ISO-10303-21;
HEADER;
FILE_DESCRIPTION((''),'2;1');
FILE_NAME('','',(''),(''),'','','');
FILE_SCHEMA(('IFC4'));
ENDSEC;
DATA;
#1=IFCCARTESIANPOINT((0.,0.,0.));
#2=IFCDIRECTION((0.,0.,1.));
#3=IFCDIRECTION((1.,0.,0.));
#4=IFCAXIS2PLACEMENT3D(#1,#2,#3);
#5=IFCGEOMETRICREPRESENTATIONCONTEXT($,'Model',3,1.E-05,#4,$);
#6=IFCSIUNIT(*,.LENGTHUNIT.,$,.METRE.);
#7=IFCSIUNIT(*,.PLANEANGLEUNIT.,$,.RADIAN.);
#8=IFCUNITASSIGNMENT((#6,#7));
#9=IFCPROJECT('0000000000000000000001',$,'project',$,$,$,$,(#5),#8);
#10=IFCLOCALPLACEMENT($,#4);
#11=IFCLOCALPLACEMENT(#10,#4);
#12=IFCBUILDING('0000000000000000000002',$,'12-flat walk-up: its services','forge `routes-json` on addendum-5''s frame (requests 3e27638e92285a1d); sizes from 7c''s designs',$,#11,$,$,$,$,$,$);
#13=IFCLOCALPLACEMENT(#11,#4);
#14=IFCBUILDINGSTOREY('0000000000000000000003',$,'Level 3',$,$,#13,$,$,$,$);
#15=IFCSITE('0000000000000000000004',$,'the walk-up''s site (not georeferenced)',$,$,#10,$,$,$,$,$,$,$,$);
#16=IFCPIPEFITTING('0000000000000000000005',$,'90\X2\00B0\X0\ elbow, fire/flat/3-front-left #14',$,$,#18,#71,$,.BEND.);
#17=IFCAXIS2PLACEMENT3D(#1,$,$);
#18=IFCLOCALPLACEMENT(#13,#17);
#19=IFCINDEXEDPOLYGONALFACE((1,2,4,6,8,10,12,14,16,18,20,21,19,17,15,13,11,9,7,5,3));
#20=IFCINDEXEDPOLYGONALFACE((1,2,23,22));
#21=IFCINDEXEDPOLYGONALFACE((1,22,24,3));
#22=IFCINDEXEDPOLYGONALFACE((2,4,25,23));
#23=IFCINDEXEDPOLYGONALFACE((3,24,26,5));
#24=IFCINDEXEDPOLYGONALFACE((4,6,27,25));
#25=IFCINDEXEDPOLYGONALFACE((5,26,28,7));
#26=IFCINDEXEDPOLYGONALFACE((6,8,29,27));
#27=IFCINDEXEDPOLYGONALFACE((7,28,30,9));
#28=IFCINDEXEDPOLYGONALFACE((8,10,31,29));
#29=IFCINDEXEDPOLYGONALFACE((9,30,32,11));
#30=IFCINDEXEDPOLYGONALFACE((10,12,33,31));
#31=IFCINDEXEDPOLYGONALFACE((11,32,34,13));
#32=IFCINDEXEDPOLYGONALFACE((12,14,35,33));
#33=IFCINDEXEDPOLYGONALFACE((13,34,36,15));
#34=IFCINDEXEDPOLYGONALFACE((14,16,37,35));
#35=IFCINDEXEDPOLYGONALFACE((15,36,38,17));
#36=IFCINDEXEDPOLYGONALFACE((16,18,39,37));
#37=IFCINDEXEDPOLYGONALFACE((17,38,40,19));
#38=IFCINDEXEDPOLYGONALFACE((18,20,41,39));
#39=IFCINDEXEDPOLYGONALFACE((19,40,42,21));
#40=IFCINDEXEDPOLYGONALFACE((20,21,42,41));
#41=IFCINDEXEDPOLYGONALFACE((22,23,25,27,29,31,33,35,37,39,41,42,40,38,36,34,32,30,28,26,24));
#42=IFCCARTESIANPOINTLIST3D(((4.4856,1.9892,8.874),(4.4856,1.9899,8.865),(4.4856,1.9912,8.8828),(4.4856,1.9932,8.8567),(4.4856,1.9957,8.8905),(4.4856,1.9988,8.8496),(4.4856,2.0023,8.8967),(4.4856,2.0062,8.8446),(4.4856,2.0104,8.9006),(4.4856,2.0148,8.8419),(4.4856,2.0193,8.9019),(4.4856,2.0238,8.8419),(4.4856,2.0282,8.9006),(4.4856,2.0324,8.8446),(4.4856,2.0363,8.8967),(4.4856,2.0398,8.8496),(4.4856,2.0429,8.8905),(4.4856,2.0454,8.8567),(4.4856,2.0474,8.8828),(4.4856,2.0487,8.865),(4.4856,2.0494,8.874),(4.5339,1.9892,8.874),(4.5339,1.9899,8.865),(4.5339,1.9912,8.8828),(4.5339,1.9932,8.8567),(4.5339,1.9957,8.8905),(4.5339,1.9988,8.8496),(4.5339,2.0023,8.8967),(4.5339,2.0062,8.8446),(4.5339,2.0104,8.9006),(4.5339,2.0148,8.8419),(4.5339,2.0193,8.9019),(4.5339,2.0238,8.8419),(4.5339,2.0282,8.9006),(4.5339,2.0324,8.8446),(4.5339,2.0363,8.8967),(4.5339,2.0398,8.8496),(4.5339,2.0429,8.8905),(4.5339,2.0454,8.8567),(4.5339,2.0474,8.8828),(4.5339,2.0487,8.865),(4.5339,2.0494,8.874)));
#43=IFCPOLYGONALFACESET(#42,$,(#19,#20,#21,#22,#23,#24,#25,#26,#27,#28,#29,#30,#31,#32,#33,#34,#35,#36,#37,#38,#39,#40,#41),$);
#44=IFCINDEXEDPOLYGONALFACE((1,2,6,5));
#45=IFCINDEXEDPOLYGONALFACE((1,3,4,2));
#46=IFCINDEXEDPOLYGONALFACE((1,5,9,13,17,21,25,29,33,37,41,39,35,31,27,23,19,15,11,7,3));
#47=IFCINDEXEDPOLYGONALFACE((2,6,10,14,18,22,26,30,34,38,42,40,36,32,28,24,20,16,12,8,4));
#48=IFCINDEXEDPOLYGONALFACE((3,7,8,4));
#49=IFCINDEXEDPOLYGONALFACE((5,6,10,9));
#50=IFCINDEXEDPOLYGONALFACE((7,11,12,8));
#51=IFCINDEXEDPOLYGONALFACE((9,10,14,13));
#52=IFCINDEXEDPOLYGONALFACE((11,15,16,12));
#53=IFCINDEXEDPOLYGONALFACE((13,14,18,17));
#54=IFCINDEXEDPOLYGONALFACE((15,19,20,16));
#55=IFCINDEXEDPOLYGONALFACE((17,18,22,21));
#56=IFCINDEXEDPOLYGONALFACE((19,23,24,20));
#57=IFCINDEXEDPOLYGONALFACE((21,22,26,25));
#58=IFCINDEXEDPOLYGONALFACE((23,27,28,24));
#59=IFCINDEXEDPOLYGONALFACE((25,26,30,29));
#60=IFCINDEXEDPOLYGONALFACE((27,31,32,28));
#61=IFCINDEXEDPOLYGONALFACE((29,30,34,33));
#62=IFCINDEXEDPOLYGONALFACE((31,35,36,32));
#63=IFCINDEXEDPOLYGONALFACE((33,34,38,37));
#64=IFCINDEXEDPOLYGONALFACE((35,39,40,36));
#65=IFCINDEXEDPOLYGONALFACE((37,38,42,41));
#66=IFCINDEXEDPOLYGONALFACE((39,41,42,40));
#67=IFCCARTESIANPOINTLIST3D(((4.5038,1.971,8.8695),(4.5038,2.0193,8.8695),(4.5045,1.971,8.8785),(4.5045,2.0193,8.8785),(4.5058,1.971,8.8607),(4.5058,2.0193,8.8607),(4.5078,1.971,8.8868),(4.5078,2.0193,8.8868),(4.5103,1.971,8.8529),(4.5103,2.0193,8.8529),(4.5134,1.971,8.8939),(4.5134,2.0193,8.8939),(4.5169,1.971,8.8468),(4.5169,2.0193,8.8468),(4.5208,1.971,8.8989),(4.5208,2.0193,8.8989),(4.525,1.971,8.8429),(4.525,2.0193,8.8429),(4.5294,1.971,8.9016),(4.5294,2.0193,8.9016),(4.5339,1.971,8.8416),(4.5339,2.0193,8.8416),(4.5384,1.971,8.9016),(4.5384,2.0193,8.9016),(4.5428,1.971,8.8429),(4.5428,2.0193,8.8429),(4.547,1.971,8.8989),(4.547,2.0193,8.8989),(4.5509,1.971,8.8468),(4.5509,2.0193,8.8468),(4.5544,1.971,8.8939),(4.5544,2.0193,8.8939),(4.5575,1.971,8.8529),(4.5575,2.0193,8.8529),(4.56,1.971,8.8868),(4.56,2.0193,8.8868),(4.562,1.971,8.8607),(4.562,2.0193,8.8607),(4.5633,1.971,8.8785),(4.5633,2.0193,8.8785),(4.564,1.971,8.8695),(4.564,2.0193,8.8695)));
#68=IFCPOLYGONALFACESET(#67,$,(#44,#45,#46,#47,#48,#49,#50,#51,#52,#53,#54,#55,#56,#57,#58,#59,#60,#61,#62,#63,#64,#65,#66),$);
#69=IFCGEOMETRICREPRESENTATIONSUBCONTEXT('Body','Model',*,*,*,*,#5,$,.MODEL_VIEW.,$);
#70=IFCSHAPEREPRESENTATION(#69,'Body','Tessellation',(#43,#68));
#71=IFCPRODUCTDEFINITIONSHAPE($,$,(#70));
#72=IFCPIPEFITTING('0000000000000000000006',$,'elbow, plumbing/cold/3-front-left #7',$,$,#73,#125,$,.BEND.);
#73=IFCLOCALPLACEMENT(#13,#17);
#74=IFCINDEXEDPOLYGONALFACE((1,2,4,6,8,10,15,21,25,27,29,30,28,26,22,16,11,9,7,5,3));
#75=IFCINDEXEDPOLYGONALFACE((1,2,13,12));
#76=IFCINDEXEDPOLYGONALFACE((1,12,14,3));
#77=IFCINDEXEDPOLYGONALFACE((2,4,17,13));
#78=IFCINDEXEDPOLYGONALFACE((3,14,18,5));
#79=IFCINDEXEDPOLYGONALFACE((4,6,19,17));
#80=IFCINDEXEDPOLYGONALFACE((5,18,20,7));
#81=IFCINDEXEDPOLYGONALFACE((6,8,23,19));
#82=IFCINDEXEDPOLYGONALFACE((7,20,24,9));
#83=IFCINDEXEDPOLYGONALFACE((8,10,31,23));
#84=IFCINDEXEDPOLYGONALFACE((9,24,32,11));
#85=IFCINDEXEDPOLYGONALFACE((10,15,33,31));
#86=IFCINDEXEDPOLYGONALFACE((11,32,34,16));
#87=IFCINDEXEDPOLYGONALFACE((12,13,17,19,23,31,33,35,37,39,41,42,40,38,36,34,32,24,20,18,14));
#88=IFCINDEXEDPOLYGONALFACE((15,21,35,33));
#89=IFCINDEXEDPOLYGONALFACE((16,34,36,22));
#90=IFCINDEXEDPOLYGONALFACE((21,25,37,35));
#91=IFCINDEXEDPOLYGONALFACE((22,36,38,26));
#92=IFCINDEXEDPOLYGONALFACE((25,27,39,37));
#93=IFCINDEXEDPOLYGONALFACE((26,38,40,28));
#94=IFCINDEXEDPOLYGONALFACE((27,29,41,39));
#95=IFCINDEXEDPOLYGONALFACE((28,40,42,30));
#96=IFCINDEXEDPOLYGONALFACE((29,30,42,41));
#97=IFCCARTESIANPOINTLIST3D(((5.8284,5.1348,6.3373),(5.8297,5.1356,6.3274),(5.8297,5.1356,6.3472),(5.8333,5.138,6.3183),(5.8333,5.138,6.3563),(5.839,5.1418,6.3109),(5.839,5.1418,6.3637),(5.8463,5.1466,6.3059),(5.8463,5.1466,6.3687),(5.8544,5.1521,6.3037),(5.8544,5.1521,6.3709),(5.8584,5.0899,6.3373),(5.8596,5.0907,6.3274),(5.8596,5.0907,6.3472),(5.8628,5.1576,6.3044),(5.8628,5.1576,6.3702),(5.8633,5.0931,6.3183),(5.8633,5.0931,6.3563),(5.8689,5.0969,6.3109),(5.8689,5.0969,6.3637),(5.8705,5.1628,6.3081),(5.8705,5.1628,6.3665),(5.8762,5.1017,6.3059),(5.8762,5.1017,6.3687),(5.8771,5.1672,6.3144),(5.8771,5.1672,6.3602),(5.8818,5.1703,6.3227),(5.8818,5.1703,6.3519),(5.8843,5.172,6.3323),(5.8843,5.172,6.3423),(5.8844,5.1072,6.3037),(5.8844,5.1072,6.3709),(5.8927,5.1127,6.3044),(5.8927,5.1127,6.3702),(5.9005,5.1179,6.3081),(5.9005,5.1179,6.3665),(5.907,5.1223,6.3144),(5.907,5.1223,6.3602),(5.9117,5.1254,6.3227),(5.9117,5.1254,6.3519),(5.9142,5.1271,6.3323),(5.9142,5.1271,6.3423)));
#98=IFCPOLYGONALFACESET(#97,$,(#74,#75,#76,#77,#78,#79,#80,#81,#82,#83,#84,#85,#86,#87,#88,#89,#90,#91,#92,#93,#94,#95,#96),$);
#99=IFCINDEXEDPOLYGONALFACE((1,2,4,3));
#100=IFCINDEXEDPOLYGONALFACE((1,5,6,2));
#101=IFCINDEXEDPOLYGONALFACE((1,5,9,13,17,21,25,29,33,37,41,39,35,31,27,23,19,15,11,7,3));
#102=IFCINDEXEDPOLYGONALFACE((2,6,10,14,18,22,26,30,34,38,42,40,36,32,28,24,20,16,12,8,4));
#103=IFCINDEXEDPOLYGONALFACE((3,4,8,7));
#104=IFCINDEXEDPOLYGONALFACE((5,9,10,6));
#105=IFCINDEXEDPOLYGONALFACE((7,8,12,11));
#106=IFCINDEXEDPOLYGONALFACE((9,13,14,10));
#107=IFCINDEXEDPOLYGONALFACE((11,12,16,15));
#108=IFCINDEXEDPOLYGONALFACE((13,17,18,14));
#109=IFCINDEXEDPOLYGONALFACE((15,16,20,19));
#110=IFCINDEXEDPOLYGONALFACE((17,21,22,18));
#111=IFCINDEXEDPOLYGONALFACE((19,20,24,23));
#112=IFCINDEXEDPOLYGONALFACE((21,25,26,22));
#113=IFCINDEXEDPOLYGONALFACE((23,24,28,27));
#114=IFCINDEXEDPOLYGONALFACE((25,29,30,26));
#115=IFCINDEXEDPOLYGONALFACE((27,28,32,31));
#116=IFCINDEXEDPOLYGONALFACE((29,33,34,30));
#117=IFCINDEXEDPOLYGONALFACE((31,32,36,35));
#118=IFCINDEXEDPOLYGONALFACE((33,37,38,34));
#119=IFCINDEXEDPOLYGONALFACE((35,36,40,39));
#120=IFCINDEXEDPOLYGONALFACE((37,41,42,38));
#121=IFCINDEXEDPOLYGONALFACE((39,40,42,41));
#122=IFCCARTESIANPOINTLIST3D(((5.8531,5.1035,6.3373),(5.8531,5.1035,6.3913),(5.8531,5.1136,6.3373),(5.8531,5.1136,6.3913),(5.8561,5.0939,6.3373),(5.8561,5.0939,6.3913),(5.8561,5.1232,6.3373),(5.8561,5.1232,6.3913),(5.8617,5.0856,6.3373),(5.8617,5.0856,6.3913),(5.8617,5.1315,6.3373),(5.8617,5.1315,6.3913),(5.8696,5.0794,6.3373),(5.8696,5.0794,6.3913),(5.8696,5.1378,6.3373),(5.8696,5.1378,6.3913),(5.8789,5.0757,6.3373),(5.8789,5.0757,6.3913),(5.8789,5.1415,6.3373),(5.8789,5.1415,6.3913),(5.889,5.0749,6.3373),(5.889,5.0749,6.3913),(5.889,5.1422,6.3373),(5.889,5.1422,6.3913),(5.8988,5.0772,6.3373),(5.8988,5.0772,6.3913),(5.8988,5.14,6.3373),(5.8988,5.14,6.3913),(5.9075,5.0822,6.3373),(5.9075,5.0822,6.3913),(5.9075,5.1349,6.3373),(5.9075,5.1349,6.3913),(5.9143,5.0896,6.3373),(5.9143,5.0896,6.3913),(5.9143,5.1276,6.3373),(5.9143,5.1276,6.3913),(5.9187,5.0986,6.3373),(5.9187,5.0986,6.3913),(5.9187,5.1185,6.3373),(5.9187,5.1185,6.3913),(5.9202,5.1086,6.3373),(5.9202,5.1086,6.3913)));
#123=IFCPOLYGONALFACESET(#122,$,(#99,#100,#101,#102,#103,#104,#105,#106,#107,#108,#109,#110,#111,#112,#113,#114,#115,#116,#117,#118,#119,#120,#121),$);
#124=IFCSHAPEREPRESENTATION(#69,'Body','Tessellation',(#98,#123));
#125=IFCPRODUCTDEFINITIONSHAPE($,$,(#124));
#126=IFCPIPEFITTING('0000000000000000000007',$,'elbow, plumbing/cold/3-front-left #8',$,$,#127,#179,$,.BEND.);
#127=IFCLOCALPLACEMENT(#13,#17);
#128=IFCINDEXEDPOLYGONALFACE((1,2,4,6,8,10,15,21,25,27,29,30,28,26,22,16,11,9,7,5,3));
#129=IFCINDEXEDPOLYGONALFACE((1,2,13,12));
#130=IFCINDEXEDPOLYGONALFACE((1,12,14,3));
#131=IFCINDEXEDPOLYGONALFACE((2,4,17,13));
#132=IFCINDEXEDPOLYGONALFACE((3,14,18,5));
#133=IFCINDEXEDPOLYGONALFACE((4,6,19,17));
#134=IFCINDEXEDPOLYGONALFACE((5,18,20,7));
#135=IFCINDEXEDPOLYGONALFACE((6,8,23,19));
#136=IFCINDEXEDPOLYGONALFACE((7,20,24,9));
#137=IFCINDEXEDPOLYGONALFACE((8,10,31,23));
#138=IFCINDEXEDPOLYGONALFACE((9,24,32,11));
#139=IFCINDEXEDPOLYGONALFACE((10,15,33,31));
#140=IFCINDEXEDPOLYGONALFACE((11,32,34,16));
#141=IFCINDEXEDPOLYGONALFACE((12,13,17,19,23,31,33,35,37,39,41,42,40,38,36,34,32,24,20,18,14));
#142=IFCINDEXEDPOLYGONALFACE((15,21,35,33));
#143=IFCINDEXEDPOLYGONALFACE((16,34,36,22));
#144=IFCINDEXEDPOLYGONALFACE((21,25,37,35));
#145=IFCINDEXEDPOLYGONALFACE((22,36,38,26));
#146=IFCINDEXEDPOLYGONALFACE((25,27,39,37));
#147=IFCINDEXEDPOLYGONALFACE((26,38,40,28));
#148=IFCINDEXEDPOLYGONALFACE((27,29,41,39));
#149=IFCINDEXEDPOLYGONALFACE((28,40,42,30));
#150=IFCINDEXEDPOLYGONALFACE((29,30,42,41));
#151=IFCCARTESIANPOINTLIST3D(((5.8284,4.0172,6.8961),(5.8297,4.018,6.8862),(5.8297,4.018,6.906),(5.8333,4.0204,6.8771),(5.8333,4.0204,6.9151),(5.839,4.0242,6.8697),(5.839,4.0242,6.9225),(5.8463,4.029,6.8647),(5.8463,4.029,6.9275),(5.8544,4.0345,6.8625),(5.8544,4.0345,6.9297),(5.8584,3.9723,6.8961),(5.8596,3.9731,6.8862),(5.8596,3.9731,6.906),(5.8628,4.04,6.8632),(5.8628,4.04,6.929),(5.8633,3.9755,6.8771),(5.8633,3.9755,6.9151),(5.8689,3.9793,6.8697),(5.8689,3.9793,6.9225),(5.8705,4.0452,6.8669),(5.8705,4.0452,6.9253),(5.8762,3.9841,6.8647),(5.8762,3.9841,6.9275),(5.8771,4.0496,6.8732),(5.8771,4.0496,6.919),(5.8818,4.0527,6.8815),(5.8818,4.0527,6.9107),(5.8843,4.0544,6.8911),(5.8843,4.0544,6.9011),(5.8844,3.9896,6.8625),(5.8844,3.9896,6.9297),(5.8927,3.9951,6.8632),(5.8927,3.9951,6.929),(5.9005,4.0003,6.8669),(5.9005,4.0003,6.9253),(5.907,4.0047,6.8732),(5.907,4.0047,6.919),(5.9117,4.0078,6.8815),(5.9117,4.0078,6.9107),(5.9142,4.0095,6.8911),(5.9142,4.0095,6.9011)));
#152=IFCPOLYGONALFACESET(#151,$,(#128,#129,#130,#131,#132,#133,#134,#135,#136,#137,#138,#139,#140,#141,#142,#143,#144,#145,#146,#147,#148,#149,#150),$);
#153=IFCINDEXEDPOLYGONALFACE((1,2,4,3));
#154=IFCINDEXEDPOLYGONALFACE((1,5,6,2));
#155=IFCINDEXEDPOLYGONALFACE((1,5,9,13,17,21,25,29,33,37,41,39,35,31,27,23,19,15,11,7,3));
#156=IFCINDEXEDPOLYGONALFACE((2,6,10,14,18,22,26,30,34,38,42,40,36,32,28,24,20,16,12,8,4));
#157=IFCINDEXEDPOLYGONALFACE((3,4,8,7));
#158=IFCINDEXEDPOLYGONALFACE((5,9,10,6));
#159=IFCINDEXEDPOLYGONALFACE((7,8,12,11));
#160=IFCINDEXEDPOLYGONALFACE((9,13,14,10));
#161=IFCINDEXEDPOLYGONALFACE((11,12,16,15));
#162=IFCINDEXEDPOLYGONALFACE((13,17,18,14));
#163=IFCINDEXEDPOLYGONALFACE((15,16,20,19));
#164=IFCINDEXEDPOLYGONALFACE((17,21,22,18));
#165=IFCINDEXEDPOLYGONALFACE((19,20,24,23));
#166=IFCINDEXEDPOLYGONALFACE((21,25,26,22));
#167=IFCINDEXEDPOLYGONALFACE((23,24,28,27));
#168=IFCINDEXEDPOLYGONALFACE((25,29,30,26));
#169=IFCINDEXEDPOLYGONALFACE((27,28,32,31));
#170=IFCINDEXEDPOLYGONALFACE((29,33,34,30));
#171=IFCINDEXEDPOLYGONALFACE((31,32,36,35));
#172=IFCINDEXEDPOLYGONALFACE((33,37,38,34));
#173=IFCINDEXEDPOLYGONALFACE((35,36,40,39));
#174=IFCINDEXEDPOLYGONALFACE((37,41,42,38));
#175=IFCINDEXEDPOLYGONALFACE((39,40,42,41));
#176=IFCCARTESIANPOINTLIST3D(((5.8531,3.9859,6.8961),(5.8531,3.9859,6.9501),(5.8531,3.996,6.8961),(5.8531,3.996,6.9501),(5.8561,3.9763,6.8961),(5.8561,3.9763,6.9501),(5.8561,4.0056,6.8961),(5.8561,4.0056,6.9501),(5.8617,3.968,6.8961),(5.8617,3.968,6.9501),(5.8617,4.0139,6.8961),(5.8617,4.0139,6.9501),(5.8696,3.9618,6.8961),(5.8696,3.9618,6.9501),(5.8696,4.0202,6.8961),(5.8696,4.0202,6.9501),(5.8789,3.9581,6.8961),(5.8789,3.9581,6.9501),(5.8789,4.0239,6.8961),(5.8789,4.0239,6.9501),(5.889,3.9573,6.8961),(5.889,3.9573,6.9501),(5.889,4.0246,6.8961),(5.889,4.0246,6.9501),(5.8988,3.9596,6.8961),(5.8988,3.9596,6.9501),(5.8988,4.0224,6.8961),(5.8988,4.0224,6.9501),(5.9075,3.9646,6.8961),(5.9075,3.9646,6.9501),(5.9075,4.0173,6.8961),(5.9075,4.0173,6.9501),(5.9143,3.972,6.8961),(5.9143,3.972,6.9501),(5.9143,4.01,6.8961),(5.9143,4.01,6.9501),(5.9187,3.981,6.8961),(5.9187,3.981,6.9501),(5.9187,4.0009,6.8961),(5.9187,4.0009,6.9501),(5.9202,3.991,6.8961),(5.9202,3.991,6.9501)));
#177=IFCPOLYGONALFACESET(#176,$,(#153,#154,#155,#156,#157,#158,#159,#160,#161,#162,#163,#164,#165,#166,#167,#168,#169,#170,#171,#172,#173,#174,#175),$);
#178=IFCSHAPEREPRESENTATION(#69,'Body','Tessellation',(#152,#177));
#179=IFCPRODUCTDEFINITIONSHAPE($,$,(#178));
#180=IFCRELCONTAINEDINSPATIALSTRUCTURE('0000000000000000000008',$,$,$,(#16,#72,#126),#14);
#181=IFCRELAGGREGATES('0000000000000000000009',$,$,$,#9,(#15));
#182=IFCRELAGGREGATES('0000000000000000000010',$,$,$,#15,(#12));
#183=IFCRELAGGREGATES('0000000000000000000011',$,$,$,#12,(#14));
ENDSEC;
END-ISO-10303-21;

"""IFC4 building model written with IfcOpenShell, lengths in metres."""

from ifc_helpers import new_model, entity, si_unit, frame, origin_with_axes, place, context, subcontext, project, spatial, element, save


model = new_model("IFC4")

# Units and contexts
model_context = context("Model", 3, precision=1e-05, world=origin_with_axes())
body_context = subcontext(model_context, "Body", "Model", "MODEL_VIEW")
ifc_project = project(units=[si_unit("LENGTHUNIT", "METRE"), si_unit("PLANEANGLEUNIT", "RADIAN")], contexts=[model_context])

# Site, building, storey
site_placement = place(None, origin_with_axes())
site = spatial("IfcSite", under=ifc_project, at=site_placement, Name="the walk-up's site (not georeferenced)")
building_placement = place(site_placement, origin_with_axes())
building = spatial("IfcBuilding", under=site, at=building_placement, Name="12-flat walk-up: its services", Description="forge `routes-json` on addendum-5's frame (requests 3e27638e92285a1d); sizes from 7c's designs")
storey_placement = place(building_placement, origin_with_axes())
storey = spatial("IfcBuildingStorey", under=building, at=storey_placement, Name="Level 3")

# Pipe fittings
pipe_fitting_1_placement = place(storey_placement, frame((4.4856, 2.0193, 8.8717), z_axis=(0.0, 0.0, 1.0), x_axis=(1.0, 0.0, 0.0)))
element("IfcPipeFitting", 1, at=pipe_fitting_1_placement, inside=storey, Name="90° elbow, fire/flat/3-front-left #14", PredefinedType="BEND", context=body_context, shape_type="AdvancedSweptSolid", body=[
    entity("IfcSweptDiskSolid", entity("IfcPolyline", [entity("IfcCartesianPoint", [0.0, 0.0, 0.0]), entity("IfcCartesianPoint", [0.0483, 0.0, 0.0])]), 0.0302),
    entity("IfcSweptDiskSolid", entity("IfcPolyline", [entity("IfcCartesianPoint", [0.0483, 0.0, 0.0]), entity("IfcCartesianPoint", [0.0483, -0.0483, 0.0])]), 0.0302),
])
pipe_fitting_2_placement = place(storey_placement, frame((5.8565, 5.1535, 6.3373), z_axis=(0.0, 0.0, 1.0), x_axis=(1.0, 0.0, 0.0)))
element("IfcPipeFitting", 2, at=pipe_fitting_2_placement, inside=storey, Name="elbow, plumbing/cold/3-front-left #7", PredefinedType="BEND", context=body_context, shape_type="AdvancedSweptSolid", body=[
    entity("IfcSweptDiskSolid", entity("IfcPolyline", [entity("IfcCartesianPoint", [0.0, 0.0, 0.0]), entity("IfcCartesianPoint", [0.0299, -0.0449, 0.0])]), 0.0337),
    entity("IfcSweptDiskSolid", entity("IfcPolyline", [entity("IfcCartesianPoint", [0.0299, -0.0449, 0.0]), entity("IfcCartesianPoint", [0.0299, -0.0449, 0.054])]), 0.0337),
])
pipe_fitting_3_placement = place(storey_placement, frame((5.8565, 4.0359, 6.8961), z_axis=(0.0, 0.0, 1.0), x_axis=(1.0, 0.0, 0.0)))
element("IfcPipeFitting", 3, at=pipe_fitting_3_placement, inside=storey, Name="elbow, plumbing/cold/3-front-left #8", PredefinedType="BEND", context=body_context, shape_type="AdvancedSweptSolid", body=[
    entity("IfcSweptDiskSolid", entity("IfcPolyline", [entity("IfcCartesianPoint", [0.0, 0.0, 0.0]), entity("IfcCartesianPoint", [0.0299, -0.0449, 0.0])]), 0.0337),
    entity("IfcSweptDiskSolid", entity("IfcPolyline", [entity("IfcCartesianPoint", [0.0299, -0.0449, 0.0]), entity("IfcCartesianPoint", [0.0299, -0.0449, 0.054])]), 0.0337),
])

save(model, "model.ifc")
